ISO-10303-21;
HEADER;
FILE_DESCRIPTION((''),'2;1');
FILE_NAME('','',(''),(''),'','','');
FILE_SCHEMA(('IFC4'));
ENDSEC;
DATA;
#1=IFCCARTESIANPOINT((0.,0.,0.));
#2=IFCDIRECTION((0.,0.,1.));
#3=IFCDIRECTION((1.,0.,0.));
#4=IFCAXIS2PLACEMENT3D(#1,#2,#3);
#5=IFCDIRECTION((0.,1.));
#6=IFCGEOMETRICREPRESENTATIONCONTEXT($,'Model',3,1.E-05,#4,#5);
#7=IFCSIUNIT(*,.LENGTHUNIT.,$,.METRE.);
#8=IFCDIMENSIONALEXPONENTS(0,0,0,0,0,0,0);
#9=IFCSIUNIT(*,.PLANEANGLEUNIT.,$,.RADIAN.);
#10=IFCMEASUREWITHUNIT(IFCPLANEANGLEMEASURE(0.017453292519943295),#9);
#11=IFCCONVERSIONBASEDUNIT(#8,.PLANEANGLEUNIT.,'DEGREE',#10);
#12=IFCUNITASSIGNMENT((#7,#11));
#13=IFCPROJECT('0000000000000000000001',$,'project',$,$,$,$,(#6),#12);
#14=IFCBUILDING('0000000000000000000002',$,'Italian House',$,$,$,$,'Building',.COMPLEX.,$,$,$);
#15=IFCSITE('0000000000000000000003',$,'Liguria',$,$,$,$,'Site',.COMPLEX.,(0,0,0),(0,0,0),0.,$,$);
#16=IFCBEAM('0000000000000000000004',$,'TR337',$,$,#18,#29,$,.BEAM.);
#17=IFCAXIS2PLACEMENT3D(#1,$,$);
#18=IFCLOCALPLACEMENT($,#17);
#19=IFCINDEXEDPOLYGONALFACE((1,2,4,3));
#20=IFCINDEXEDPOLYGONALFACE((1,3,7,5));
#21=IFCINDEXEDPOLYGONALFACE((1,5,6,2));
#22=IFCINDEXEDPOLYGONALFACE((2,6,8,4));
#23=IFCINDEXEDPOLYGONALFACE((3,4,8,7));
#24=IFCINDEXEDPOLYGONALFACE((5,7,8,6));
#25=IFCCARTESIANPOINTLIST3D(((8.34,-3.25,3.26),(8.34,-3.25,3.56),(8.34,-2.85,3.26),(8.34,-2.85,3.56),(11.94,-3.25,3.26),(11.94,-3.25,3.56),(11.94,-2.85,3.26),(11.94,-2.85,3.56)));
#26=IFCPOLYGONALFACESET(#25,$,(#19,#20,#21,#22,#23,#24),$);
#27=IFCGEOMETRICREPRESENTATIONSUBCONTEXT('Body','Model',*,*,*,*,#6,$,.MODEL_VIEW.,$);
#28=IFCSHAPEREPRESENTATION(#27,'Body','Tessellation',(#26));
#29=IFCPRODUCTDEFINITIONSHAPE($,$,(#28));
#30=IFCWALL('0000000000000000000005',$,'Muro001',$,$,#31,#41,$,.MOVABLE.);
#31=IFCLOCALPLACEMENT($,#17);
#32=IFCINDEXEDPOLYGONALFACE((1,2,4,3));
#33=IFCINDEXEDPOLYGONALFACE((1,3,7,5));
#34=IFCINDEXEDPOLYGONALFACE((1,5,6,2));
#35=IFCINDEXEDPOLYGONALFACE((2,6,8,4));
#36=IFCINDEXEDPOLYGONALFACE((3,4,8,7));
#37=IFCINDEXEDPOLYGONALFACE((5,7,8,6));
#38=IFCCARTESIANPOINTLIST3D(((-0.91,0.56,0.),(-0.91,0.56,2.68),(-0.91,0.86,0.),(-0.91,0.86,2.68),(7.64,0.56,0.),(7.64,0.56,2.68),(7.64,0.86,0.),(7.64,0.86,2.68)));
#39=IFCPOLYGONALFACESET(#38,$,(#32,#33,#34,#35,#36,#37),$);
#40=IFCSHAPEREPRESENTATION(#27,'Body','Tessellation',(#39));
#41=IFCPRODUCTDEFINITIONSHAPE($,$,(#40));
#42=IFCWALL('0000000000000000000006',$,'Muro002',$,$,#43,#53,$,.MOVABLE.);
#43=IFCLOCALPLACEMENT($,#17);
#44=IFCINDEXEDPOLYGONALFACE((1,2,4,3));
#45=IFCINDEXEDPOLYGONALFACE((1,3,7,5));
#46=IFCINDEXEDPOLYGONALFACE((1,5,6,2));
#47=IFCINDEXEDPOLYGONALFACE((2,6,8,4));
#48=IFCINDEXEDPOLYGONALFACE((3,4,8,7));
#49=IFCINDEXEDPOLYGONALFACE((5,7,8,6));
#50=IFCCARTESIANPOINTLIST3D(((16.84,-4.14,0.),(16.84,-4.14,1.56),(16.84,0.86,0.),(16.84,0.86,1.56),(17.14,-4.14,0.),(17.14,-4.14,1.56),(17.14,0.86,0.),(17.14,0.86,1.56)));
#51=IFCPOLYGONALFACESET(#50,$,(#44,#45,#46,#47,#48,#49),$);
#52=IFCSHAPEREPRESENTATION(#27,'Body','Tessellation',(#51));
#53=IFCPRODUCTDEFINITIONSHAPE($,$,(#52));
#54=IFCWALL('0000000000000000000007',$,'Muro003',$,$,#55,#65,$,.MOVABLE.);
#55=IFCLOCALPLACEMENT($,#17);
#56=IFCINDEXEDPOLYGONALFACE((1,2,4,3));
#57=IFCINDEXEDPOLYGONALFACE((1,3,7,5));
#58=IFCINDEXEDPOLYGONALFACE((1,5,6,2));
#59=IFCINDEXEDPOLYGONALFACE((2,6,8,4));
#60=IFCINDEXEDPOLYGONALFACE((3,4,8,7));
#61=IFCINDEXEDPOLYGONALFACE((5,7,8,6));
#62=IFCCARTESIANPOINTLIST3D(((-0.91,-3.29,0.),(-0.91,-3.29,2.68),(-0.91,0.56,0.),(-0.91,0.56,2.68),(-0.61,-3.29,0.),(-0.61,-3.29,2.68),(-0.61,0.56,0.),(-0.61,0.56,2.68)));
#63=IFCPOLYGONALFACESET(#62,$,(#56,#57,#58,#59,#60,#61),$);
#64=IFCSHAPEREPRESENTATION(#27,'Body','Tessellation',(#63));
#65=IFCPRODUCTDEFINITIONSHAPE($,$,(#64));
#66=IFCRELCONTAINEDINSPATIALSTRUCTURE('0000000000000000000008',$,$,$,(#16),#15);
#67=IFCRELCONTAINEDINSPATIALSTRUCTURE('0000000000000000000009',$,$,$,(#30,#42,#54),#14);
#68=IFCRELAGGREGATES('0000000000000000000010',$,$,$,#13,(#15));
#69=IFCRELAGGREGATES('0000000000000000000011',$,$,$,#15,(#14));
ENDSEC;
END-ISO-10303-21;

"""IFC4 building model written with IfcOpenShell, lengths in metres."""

from ifc_helpers import new_model, entity, si_unit, converted_unit, direction, frame, frame_2d, origin_with_axes, origin_2d_with_axis, place, context, subcontext, project, spatial, rectangle, extrude, element, save


model = new_model("IFC4")

# Units and contexts
model_context = context("Model", 3, precision=1e-05, world=origin_with_axes(), true_north=direction((0.0, 1.0)))
body_context = subcontext(model_context, "Body", "Model", "MODEL_VIEW")
ifc_project = project(units=[si_unit("LENGTHUNIT", "METRE"), converted_unit("PLANEANGLEUNIT", "DEGREE", entity("IfcPlaneAngleMeasure", 0.017453292519943295), si_unit("PLANEANGLEUNIT", "RADIAN"), dimensions=[0, 0, 0, 0, 0, 0, 0])], contexts=[model_context])

# Site
site = spatial("IfcSite", under=ifc_project, Name="Liguria", LongName="Site", CompositionType="COMPLEX", RefLatitude=(0, 0, 0), RefLongitude=(0, 0, 0), RefElevation=0.0)

# Beam
beam_placement = place(None, origin_with_axes())
element("IfcBeam", 1, at=beam_placement, inside=site, Name="TR337", PredefinedType="BEAM", context=body_context, shape_type="SweptSolid", body=[
    extrude(rectangle(XDim=0.4, YDim=0.3, at=frame_2d((0.0, 0.0), x_axis=(0.0, 1.0))), frame((11.94, -3.05, 3.41), z_axis=(-1.0, 0.0, 0.0), x_axis=(0.0, 0.0, -1.0)), (0.0, 0.0, 1.0), 3.6),
])

# Shared definitions
building = spatial("IfcBuilding", under=site, Name="Italian House", LongName="Building", CompositionType="COMPLEX")

# Walls
placement = place(None, origin_with_axes())
element("IfcWall", 2, at=placement, inside=building, Name="Muro001", PredefinedType="MOVABLE", context=body_context, shape_type="SweptSolid", body=[
    extrude(rectangle(XDim=8.55, YDim=0.3, at=origin_2d_with_axis()), frame((3.365, 0.71, 0.0), z_axis=(0.0, 0.0, 1.0), x_axis=(1.0, 0.0, 0.0)), (0.0, 0.0, 1.0), 2.68),
])
element("IfcWall", 3, at=placement, inside=building, Name="Muro002", PredefinedType="MOVABLE", context=body_context, shape_type="SweptSolid", body=[
    extrude(rectangle(XDim=5.0, YDim=0.3, at=frame_2d((0.0, 0.0), x_axis=(0.0, 1.0))), frame((16.99, -1.64, 0.0), z_axis=(0.0, 0.0, 1.0), x_axis=(1.0, 0.0, 0.0)), (0.0, 0.0, 1.0), 1.56),
])
element("IfcWall", 4, at=placement, inside=building, Name="Muro003", PredefinedType="MOVABLE", context=body_context, shape_type="SweptSolid", body=[
    extrude(rectangle(XDim=3.85, YDim=0.3, at=frame_2d((0.0, 0.0), x_axis=(0.0, 1.0))), frame((-0.76, -1.365, 0.0), z_axis=(0.0, 0.0, 1.0), x_axis=(1.0, 0.0, 0.0)), (0.0, 0.0, 1.0), 2.68),
])

save(model, "model.ifc")
